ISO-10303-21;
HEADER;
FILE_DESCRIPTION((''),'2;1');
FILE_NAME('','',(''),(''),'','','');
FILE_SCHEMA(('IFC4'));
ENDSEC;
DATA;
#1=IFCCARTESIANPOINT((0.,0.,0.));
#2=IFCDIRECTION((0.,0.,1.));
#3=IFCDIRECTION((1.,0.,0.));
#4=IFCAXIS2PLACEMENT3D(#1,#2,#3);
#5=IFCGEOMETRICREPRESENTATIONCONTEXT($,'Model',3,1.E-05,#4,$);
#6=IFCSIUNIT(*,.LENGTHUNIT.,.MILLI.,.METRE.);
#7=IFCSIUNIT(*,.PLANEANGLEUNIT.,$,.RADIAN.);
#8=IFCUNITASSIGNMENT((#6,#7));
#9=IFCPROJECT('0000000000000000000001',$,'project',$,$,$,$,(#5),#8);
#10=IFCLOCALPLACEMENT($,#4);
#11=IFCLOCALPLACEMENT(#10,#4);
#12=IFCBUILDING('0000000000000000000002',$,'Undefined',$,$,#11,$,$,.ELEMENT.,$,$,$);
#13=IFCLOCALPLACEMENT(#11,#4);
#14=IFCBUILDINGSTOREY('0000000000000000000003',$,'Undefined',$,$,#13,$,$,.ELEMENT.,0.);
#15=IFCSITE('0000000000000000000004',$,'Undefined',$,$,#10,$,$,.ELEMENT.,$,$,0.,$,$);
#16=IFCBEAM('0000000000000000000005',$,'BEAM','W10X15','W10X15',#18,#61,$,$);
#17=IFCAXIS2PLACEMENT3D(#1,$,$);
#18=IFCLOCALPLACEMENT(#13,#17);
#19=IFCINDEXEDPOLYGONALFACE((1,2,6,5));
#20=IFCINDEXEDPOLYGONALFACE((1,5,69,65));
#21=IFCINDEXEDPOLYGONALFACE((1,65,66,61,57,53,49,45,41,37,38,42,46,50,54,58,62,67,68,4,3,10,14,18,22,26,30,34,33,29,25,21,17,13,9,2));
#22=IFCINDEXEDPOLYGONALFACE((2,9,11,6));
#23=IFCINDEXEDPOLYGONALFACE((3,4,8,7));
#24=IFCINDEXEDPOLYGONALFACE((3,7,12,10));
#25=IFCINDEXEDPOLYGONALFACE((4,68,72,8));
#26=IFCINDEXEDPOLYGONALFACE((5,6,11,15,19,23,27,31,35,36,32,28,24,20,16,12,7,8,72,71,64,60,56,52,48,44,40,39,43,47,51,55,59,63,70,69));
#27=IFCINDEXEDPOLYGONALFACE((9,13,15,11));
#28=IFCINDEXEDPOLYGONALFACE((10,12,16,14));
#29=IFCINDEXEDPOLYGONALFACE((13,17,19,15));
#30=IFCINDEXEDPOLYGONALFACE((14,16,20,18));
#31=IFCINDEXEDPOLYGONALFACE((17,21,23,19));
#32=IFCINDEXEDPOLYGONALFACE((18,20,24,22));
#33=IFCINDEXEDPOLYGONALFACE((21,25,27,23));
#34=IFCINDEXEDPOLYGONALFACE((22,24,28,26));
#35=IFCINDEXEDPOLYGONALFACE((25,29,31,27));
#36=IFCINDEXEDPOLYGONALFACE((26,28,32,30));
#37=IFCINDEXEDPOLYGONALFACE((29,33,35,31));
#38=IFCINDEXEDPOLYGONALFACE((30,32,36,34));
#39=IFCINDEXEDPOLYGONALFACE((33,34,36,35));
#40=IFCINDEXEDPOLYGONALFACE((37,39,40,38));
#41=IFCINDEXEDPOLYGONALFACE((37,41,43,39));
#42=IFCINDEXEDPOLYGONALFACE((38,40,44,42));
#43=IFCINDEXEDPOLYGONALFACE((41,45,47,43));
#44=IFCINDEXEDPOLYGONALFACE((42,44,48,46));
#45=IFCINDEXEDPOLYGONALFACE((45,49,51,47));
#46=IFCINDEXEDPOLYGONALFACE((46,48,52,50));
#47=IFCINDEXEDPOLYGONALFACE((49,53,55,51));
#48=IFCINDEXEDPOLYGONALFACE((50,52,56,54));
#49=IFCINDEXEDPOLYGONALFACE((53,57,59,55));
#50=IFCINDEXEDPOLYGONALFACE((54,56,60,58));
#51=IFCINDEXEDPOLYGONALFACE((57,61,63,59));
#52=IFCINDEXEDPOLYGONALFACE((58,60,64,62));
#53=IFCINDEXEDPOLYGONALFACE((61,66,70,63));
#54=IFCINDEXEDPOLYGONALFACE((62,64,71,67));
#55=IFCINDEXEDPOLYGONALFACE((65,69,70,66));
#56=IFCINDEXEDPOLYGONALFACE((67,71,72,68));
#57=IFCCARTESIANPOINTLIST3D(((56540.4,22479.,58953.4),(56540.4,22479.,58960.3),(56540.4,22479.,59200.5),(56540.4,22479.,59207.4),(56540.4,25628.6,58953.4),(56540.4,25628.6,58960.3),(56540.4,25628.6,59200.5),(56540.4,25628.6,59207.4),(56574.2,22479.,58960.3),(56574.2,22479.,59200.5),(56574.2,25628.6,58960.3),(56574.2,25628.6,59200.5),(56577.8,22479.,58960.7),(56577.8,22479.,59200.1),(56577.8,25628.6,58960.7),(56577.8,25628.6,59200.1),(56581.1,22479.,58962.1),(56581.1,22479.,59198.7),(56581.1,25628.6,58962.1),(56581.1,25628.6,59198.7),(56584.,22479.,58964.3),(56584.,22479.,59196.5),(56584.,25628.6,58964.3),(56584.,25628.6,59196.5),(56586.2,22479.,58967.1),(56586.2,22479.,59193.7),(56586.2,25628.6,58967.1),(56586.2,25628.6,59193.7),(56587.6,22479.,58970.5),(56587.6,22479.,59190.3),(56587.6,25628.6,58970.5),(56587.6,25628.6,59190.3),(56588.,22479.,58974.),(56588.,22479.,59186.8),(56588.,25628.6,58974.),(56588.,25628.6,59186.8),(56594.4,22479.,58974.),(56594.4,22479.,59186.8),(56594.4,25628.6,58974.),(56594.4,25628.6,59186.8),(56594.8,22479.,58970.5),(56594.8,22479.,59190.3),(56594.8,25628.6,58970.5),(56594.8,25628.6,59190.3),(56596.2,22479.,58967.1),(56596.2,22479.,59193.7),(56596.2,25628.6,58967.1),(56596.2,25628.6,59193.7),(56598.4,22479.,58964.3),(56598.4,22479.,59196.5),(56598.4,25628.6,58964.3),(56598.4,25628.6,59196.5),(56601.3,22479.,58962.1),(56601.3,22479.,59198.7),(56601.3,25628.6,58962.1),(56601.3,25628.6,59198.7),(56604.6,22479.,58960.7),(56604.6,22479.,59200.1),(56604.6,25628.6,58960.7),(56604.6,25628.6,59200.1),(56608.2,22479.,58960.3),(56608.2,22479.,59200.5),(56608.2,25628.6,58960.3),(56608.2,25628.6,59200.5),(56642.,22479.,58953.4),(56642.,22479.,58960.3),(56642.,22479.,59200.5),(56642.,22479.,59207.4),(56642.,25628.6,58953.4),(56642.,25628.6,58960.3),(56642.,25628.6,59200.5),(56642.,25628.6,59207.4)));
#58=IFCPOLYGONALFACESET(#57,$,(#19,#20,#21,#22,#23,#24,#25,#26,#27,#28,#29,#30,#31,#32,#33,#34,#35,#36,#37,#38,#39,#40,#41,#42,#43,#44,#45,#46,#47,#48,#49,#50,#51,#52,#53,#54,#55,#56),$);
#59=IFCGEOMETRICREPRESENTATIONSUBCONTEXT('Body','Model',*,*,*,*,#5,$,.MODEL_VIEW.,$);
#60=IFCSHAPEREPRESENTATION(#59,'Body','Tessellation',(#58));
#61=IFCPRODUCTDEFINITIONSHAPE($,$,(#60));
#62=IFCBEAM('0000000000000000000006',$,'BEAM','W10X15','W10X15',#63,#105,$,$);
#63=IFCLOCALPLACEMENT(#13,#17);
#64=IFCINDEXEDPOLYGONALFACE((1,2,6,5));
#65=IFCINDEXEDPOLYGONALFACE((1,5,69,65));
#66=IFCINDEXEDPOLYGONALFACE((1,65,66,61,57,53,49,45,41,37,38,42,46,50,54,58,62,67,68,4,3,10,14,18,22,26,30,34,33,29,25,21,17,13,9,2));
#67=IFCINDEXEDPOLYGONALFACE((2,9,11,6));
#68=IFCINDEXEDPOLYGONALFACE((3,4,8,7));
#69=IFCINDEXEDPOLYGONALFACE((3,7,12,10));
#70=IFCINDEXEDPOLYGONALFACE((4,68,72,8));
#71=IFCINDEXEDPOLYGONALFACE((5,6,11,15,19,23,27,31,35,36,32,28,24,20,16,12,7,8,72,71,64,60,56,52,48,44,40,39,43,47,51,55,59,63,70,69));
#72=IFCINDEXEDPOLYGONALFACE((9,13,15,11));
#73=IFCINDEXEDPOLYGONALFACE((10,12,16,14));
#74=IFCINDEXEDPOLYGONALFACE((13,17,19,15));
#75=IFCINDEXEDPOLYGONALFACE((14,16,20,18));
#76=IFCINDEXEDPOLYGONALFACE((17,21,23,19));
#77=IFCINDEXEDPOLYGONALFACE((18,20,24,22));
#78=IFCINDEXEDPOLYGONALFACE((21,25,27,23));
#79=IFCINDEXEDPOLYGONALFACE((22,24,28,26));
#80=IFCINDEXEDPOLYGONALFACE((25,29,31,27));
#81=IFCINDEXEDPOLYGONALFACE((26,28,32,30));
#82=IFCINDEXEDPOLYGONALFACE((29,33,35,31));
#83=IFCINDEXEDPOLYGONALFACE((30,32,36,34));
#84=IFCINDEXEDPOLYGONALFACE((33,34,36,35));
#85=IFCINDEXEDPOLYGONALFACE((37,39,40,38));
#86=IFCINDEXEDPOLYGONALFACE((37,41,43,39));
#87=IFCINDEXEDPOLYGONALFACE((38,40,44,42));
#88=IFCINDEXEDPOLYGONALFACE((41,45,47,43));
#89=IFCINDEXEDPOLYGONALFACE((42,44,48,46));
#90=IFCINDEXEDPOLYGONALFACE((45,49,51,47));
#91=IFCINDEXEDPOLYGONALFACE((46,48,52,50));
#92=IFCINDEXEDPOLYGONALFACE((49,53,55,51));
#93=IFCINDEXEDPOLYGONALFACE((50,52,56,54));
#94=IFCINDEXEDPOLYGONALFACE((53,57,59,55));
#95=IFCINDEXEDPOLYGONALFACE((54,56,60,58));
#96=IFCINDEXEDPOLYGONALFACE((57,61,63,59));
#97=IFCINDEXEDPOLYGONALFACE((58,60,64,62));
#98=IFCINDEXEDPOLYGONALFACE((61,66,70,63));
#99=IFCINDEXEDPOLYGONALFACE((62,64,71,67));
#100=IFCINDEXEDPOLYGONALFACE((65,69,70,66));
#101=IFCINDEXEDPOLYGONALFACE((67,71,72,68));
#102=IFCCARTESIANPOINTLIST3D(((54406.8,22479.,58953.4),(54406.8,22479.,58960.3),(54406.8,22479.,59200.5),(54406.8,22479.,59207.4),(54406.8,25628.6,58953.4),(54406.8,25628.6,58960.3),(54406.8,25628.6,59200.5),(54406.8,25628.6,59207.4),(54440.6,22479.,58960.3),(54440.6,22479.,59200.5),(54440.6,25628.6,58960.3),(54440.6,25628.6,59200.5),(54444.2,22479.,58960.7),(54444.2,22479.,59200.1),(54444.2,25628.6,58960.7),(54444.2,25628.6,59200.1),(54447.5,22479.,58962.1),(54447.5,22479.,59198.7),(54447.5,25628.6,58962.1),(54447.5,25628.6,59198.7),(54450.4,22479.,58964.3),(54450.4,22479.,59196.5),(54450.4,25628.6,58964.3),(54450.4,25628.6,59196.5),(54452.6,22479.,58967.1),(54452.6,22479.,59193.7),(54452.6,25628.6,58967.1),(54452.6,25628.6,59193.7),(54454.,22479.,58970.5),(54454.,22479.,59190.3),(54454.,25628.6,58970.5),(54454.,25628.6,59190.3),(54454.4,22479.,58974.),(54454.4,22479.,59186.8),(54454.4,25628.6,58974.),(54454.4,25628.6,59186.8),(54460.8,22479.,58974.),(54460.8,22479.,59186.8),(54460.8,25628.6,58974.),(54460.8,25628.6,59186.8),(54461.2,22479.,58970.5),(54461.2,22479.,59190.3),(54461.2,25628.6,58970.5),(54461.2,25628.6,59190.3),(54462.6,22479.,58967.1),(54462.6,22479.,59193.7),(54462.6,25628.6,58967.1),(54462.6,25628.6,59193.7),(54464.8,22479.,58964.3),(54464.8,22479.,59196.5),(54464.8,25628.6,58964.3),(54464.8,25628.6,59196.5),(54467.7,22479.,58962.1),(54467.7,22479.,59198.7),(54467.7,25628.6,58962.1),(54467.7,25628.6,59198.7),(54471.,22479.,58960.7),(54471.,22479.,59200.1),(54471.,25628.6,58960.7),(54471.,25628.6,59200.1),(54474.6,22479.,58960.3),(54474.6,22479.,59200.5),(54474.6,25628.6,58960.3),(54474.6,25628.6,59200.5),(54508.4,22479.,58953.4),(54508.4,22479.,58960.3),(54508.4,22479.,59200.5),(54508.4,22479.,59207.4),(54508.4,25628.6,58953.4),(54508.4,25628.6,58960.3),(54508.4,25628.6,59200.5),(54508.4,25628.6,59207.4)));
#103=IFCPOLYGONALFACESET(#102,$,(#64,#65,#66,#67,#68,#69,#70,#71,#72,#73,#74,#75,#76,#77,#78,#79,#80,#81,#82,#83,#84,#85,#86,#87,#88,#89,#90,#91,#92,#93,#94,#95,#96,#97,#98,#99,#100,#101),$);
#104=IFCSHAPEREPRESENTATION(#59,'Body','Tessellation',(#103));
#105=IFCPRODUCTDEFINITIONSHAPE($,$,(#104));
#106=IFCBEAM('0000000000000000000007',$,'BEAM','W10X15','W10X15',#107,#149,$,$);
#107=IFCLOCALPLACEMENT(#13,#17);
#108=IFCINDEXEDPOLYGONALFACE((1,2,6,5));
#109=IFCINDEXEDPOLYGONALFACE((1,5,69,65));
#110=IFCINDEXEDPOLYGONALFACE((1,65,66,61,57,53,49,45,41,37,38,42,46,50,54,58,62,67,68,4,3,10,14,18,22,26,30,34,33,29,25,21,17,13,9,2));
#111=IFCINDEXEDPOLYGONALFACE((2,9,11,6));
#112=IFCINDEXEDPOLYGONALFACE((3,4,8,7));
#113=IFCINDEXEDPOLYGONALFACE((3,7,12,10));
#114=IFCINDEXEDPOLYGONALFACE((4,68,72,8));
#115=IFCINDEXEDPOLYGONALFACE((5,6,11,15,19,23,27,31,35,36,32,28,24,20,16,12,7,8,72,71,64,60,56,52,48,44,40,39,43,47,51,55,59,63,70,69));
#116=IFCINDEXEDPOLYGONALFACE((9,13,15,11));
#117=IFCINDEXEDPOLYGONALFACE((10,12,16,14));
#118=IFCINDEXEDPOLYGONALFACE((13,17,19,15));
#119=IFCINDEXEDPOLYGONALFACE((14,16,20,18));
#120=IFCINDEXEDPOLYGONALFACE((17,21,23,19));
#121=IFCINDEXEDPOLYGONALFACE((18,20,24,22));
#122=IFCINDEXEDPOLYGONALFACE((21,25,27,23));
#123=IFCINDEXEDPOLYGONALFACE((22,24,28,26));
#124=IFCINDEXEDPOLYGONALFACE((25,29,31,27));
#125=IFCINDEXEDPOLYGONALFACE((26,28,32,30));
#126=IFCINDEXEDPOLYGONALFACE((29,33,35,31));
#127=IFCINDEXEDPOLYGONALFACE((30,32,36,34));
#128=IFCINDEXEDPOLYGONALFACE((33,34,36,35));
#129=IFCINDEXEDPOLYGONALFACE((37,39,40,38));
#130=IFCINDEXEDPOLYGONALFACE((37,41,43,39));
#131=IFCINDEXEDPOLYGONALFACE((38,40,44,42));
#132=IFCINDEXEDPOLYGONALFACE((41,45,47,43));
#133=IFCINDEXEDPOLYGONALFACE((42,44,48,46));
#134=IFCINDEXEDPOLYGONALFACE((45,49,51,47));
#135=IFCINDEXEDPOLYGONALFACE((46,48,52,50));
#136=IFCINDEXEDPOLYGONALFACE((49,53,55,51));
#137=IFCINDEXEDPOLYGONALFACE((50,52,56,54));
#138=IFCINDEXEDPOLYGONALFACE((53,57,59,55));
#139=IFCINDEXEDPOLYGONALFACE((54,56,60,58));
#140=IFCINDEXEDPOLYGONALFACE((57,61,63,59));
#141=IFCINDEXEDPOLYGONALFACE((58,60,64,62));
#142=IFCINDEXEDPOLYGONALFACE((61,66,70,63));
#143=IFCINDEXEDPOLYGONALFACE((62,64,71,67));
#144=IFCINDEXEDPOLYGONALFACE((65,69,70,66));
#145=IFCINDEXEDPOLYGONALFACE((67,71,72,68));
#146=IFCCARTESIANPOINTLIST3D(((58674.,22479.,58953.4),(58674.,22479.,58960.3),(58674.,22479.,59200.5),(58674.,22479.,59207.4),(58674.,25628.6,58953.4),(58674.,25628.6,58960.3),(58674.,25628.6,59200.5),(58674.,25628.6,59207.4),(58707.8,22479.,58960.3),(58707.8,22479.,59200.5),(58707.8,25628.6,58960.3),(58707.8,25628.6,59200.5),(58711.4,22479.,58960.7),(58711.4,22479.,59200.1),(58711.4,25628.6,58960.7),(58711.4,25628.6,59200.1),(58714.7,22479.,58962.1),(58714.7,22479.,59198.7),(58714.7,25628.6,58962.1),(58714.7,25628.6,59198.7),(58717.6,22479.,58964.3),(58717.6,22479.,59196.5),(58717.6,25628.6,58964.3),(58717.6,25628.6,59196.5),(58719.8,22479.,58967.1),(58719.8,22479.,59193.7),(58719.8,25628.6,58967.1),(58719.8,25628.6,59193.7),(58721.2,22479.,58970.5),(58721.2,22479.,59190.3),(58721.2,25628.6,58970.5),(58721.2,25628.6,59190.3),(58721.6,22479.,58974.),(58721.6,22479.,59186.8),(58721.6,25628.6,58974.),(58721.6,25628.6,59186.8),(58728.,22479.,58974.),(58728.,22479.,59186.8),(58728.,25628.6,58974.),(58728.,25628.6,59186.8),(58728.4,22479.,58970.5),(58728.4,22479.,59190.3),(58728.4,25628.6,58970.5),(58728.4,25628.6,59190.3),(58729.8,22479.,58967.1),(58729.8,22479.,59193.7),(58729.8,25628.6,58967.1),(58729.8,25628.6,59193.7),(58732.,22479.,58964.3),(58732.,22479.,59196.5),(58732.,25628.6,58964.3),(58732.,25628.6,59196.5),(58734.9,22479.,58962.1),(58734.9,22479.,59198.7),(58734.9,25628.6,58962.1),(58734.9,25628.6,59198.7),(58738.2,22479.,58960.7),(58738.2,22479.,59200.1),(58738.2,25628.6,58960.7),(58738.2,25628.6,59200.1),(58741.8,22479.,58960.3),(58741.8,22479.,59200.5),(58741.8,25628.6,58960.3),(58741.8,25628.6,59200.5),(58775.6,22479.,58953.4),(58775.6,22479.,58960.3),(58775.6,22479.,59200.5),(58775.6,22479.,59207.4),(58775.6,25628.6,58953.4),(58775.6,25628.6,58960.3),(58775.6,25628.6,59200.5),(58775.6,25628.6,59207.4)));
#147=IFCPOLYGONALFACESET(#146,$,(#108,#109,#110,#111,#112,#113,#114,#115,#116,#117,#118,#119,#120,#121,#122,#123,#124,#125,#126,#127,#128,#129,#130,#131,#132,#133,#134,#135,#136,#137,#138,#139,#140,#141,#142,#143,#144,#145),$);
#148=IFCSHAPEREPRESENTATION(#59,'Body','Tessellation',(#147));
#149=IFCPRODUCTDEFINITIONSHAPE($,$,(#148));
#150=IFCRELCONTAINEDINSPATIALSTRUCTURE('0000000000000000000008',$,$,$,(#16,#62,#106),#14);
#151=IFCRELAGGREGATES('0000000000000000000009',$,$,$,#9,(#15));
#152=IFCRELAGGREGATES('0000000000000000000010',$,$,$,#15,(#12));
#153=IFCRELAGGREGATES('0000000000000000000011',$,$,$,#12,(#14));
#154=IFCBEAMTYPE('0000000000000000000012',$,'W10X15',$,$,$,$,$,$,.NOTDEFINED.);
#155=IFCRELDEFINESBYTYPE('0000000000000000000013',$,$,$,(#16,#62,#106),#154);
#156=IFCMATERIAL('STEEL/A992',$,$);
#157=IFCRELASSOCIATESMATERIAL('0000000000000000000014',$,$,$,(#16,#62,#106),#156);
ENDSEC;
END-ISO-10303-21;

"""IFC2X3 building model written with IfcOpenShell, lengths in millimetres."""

from ifc_helpers import new_model, si_unit, frame, origin_with_axes, origin_2d_with_axis, place, context, subcontext, project, spatial, i_section, extrude, material, type_object, element, save


model = new_model("IFC2X3")

# Units and contexts
model_context = context("Model", 3, precision=1e-05, world=origin_with_axes())
body_context = subcontext(model_context, "Body", "Model", "MODEL_VIEW")
ifc_project = project(units=[si_unit("LENGTHUNIT", "METRE", prefix="MILLI"), si_unit("PLANEANGLEUNIT", "RADIAN")], contexts=[model_context])

# Site, building, storey
site_placement = place(None, origin_with_axes())
site = spatial("IfcSite", under=ifc_project, at=site_placement, Name="Undefined", CompositionType="ELEMENT", RefElevation=0.0)
building_placement = place(site_placement, origin_with_axes())
building = spatial("IfcBuilding", under=site, at=building_placement, Name="Undefined", CompositionType="ELEMENT")
storey_placement = place(building_placement, origin_with_axes())
storey = spatial("IfcBuildingStorey", under=building, at=storey_placement, Name="Undefined", CompositionType="ELEMENT", Elevation=0.0)

# Shared definitions
ifc_material_1 = material(Name="STEEL/A992")

# Beams
beam_type_1 = type_object("IfcBeamType", Name="W10X15", PredefinedType="NOTDEFINED")
for number, where, z_axis, x_axis, name in (
    (1, (56591.2, 22479.0, 59080.4), (0.0, 0.0, 1.0), (0.0, 1.0, 0.0), "BEAM"),
    (2, (54457.6, 22479.0, 59080.4), (0.0, 0.0, 1.0), (0.0, 1.0, 0.0), "BEAM"),
    (3, (58724.8, 22479.0, 59080.4), (0.0, 0.0, 1.0), (0.0, 1.0, 0.0), "BEAM"),
):
    element("IfcBeam", number, at=place(storey_placement, frame(where, z_axis=z_axis, x_axis=x_axis)), inside=storey, type_object=beam_type_1, material=ifc_material_1, Name=name, Description="W10X15", ObjectType="W10X15", context=body_context, shape_type="SweptSolid", body=[
        extrude(i_section(OverallWidth=101.6, OverallDepth=254.0, WebThickness=6.3, FlangeThickness=6.9, FilletRadius=13.8, at=origin_2d_with_axis()), frame((3149.6, 0.0, 0.0), z_axis=(-1.0, 0.0, 0.0), x_axis=(0.0, -1.0, 0.0)), (0.0, 0.0, 1.0), 3149.6),
    ])

save(model, "model.ifc")
